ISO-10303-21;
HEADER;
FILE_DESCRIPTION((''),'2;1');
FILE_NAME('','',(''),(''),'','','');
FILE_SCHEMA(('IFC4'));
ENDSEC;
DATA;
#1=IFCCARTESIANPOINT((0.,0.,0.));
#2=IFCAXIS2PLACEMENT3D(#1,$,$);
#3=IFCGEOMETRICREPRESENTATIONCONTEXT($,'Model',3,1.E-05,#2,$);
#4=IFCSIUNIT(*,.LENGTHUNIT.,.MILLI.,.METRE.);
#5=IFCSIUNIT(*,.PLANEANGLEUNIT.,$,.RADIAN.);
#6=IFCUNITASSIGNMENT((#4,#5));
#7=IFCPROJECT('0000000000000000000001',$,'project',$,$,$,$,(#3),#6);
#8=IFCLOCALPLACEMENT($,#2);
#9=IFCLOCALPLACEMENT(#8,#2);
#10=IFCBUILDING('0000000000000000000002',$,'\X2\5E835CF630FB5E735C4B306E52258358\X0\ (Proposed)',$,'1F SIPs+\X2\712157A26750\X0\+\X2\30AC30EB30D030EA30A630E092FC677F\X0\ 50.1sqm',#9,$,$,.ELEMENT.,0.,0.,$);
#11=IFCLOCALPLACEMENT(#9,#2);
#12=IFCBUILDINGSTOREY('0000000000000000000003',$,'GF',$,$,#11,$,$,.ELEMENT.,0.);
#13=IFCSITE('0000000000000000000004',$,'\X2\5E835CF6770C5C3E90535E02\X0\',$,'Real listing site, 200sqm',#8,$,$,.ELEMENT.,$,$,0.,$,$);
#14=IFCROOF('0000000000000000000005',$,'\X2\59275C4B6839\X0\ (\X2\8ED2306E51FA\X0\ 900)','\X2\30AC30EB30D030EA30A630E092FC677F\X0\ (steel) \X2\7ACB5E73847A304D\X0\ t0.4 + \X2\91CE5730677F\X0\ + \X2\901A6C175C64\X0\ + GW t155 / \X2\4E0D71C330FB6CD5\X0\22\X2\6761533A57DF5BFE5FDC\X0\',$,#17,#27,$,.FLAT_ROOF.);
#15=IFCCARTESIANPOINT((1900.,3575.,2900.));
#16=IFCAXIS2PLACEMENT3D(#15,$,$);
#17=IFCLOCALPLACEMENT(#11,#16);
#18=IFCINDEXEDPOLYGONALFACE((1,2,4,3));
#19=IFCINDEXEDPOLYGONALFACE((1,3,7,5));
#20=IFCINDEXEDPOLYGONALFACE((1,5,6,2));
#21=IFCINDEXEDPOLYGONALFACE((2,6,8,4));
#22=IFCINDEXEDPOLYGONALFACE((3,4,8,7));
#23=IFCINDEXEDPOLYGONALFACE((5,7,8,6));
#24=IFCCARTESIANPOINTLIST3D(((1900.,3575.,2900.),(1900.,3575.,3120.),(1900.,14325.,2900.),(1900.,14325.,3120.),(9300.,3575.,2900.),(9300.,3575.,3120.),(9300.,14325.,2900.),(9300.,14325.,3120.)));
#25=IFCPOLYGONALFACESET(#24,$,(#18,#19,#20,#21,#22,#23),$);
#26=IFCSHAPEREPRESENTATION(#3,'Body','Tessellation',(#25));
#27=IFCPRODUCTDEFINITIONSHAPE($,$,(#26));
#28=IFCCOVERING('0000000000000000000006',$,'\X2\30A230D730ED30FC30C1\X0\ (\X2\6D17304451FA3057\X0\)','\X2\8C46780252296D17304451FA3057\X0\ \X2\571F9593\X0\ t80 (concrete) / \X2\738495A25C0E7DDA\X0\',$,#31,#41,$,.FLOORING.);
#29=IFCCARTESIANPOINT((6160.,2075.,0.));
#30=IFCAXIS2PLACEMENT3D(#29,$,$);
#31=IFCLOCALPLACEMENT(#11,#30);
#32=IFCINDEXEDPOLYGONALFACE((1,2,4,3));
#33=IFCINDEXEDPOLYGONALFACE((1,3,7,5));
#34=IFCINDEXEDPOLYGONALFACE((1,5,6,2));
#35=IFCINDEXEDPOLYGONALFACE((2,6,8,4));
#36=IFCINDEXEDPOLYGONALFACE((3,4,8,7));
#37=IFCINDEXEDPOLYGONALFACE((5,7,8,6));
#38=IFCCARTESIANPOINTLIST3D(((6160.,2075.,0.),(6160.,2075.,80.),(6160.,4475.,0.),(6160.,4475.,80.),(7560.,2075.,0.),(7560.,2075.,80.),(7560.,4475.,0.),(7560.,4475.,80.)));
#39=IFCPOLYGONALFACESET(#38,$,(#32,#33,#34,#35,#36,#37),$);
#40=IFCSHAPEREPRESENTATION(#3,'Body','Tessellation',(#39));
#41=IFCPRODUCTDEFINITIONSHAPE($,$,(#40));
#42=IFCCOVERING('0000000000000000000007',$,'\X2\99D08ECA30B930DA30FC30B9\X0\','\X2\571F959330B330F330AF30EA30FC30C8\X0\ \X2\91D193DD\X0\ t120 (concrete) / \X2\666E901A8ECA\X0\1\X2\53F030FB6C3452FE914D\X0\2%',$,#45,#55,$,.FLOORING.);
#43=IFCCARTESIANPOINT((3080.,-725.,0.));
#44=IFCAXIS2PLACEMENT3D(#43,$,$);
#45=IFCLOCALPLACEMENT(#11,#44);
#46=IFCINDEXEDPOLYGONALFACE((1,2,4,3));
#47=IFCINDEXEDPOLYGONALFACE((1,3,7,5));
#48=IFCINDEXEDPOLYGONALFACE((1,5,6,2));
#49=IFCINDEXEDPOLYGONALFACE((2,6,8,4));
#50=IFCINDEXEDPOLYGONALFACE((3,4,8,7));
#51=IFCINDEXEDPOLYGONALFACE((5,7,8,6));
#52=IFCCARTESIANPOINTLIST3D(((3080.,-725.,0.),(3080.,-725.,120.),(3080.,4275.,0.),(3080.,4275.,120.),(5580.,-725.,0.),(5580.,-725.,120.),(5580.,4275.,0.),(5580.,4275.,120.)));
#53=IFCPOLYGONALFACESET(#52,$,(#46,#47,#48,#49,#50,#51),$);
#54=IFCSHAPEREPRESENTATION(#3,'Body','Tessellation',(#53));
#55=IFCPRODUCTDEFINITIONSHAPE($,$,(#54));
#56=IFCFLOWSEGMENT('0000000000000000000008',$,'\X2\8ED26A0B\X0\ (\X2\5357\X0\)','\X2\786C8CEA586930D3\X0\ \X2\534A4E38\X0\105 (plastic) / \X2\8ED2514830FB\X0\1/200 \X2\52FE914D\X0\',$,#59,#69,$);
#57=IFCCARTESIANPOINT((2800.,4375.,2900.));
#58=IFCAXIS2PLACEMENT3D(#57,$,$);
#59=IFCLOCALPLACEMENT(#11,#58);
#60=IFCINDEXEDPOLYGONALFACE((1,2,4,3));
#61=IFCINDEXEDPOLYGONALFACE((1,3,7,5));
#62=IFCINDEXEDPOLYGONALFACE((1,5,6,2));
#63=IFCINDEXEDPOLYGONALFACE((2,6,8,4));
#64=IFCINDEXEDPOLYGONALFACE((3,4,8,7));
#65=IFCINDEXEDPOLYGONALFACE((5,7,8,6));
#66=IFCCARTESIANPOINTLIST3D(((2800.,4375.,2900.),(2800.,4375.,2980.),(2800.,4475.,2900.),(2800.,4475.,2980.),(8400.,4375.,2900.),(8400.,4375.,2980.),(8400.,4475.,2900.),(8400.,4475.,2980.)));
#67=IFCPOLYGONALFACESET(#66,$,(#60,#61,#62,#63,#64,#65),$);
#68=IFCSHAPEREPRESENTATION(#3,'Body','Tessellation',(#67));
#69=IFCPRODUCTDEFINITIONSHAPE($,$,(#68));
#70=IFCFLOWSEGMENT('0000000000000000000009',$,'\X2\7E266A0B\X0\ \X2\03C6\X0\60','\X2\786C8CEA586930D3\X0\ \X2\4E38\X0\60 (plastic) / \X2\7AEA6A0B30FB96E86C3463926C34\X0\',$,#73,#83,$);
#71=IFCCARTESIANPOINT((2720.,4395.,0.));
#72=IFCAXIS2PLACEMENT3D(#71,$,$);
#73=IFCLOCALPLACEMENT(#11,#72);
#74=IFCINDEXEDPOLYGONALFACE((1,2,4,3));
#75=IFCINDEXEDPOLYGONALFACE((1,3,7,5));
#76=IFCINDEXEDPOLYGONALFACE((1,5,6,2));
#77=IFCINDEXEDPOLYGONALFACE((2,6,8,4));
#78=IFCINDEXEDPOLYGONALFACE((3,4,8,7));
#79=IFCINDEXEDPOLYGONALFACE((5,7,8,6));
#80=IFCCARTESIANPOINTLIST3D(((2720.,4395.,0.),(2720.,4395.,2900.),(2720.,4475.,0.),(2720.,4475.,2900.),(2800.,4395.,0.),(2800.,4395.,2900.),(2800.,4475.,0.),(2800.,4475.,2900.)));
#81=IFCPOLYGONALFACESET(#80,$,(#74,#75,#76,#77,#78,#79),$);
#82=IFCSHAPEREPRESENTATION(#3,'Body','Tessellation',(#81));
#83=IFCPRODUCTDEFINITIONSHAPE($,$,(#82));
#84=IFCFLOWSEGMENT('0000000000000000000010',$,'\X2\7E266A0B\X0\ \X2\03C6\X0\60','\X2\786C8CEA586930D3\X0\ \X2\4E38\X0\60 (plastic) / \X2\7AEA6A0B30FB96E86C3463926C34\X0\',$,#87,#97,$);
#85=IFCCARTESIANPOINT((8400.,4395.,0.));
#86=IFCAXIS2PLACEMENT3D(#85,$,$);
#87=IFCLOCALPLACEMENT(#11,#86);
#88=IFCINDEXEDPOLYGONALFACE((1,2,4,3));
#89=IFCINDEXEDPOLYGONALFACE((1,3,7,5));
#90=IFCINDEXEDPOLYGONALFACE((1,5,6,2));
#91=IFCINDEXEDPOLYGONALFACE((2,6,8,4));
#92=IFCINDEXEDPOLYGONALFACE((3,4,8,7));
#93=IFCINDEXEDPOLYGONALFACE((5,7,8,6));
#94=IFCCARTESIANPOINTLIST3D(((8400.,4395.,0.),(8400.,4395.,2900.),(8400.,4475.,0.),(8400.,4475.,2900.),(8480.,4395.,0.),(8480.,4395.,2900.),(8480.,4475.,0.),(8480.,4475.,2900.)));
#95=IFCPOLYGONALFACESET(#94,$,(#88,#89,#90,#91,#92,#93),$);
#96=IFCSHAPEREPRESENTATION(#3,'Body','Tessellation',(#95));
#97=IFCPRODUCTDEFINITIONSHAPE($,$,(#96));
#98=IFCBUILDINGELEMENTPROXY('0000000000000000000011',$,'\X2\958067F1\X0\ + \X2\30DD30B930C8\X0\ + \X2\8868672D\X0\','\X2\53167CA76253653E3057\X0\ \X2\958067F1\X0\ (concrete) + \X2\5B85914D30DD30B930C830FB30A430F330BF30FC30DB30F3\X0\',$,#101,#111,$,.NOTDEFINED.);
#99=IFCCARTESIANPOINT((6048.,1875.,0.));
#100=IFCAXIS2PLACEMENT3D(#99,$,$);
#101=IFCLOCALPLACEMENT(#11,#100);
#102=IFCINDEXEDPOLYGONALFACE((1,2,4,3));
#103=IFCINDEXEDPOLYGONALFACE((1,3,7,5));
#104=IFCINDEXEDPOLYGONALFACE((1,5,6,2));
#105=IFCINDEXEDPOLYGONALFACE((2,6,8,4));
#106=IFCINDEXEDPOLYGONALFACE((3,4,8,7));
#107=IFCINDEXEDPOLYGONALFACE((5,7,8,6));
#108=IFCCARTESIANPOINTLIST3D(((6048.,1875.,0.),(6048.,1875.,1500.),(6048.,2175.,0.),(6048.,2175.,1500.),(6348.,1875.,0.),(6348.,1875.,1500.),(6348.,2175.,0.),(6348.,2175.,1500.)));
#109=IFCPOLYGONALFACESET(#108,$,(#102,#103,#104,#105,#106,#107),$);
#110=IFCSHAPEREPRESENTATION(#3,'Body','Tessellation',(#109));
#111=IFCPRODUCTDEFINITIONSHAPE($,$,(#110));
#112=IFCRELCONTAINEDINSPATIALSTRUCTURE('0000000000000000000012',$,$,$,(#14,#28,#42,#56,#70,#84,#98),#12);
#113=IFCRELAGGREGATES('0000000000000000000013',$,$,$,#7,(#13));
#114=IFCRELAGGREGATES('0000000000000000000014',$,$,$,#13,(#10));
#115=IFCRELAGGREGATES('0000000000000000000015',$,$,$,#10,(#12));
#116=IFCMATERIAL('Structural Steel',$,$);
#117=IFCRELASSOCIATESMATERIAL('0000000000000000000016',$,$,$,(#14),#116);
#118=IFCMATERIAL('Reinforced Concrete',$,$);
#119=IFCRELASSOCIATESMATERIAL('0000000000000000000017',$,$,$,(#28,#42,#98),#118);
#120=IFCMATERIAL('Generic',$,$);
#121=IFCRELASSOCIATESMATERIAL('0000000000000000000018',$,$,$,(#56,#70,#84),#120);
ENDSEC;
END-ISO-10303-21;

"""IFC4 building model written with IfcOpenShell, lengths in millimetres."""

from ifc_helpers import new_model, si_unit, frame, frame_2d, origin, place, context, project, spatial, rectangle, extrude, material, element, save


model = new_model("IFC4")

# Units and contexts
model_context = context("Model", 3, precision=1e-05, world=origin())
ifc_project = project(units=[si_unit("LENGTHUNIT", "METRE", prefix="MILLI"), si_unit("PLANEANGLEUNIT", "RADIAN")], contexts=[model_context])

# Site, building, storey
site_placement = place(None, origin())
site = spatial("IfcSite", under=ifc_project, at=site_placement, Name="広島県尾道市", ObjectType="Real listing site, 200sqm", CompositionType="ELEMENT", RefElevation=0.0)
building_placement = place(site_placement, origin())
building = spatial("IfcBuilding", under=site, at=building_placement, Name="広島・平屋の別荘 (Proposed)", ObjectType="1F SIPs+無垢材+ガルバリウム鋼板 50.1sqm", CompositionType="ELEMENT", ElevationOfRefHeight=0.0, ElevationOfTerrain=0.0)
storey_placement = place(building_placement, origin())
storey = spatial("IfcBuildingStorey", under=building, at=storey_placement, Name="GF", CompositionType="ELEMENT", Elevation=0.0)

# Shared definitions
ifc_material_1 = material(Name="Reinforced Concrete")

# Roof
ifc_material_2 = material(Name="Structural Steel")
roof_placement = place(storey_placement, frame((1900.0, 3575.0, 2900.0)))
element("IfcRoof", 1, at=roof_placement, inside=storey, material=ifc_material_2, Name="大屋根 (軒の出 900)", Description="ガルバリウム鋼板 (steel) 立平葺き t0.4 + 野地板 + 通気層 + GW t155 / 不燃・法22条区域対応", PredefinedType="FLAT_ROOF", context=model_context, shape_type="SweptSolid", body=[
    extrude(rectangle(XDim=7400.0, YDim=10750.0, at=frame_2d((3700.0, 5375.0))), frame((1900.0, 3575.0, 2900.0)), (0.0, 0.0, 1.0), 220.0),
])

# Coverings
covering_1_placement = place(storey_placement, frame((6160.0, 2075.0, 0.0)))
element("IfcCovering", 2, at=covering_1_placement, inside=storey, material=ifc_material_1, Name="アプローチ (洗い出し)", Description="豆砂利洗い出し 土間 t80 (concrete) / 玄関導線", PredefinedType="FLOORING", context=model_context, shape_type="SweptSolid", body=[
    extrude(rectangle(XDim=1400.0, YDim=2400.0, at=frame_2d((700.0, 1200.0))), frame((6160.0, 2075.0, 0.0)), (0.0, 0.0, 1.0), 80.0),
])
covering_2_placement = place(storey_placement, frame((3080.0, -725.0, 0.0)))
element("IfcCovering", 3, at=covering_2_placement, inside=storey, material=ifc_material_1, Name="駐車スペース", Description="土間コンクリート 金鏝 t120 (concrete) / 普通車1台・水勾配2%", PredefinedType="FLOORING", context=model_context, shape_type="SweptSolid", body=[
    extrude(rectangle(XDim=2500.0, YDim=5000.0, at=frame_2d((1250.0, 2500.0))), frame((3080.0, -725.0, 0.0)), (0.0, 0.0, 1.0), 120.0),
])

# Flow segments
ifc_material_3 = material(Name="Generic")
flow_segment_1_placement = place(storey_placement, frame((2800.0, 4375.0, 2900.0)))
element("IfcFlowSegment", 4, at=flow_segment_1_placement, inside=storey, material=ifc_material_3, Name="軒樋 (南)", Description="硬質塩ビ 半丸105 (plastic) / 軒先・1/200 勾配", context=model_context, shape_type="SweptSolid", body=[
    extrude(rectangle(XDim=5600.0, YDim=100.0, at=frame_2d((2800.0, 50.0))), frame((2800.0, 4375.0, 2900.0)), (0.0, 0.0, 1.0), 80.0),
])
flow_segment_2_placement = place(storey_placement, frame((2720.0, 4395.0, 0.0)))
element("IfcFlowSegment", 5, at=flow_segment_2_placement, inside=storey, material=ifc_material_3, Name="縦樋 φ60", Description="硬質塩ビ 丸60 (plastic) / 竪樋・雨水排水", context=model_context, shape_type="SweptSolid", body=[
    extrude(rectangle(XDim=80.0, YDim=80.0, at=frame_2d((40.0, 40.0))), frame((2720.0, 4395.0, 0.0)), (0.0, 0.0, 1.0), 2900.0),
])
flow_segment_3_placement = place(storey_placement, frame((8400.0, 4395.0, 0.0)))
element("IfcFlowSegment", 6, at=flow_segment_3_placement, inside=storey, material=ifc_material_3, Name="縦樋 φ60", Description="硬質塩ビ 丸60 (plastic) / 竪樋・雨水排水", context=model_context, shape_type="SweptSolid", body=[
    extrude(rectangle(XDim=80.0, YDim=80.0, at=frame_2d((40.0, 40.0))), frame((8400.0, 4395.0, 0.0)), (0.0, 0.0, 1.0), 2900.0),
])

# Building element proxy
proxy_placement = place(storey_placement, frame((6048.0, 1875.0, 0.0)))
element("IfcBuildingElementProxy", 7, at=proxy_placement, inside=storey, material=ifc_material_1, Name="門柱 + ポスト + 表札", Description="化粧打放し 門柱 (concrete) + 宅配ポスト・インターホン", PredefinedType="NOTDEFINED", context=model_context, shape_type="SweptSolid", body=[
    extrude(rectangle(XDim=300.0, YDim=300.0, at=frame_2d((150.0, 150.0))), frame((6048.0, 1875.0, 0.0)), (0.0, 0.0, 1.0), 1500.0),
])

save(model, "model.ifc")
